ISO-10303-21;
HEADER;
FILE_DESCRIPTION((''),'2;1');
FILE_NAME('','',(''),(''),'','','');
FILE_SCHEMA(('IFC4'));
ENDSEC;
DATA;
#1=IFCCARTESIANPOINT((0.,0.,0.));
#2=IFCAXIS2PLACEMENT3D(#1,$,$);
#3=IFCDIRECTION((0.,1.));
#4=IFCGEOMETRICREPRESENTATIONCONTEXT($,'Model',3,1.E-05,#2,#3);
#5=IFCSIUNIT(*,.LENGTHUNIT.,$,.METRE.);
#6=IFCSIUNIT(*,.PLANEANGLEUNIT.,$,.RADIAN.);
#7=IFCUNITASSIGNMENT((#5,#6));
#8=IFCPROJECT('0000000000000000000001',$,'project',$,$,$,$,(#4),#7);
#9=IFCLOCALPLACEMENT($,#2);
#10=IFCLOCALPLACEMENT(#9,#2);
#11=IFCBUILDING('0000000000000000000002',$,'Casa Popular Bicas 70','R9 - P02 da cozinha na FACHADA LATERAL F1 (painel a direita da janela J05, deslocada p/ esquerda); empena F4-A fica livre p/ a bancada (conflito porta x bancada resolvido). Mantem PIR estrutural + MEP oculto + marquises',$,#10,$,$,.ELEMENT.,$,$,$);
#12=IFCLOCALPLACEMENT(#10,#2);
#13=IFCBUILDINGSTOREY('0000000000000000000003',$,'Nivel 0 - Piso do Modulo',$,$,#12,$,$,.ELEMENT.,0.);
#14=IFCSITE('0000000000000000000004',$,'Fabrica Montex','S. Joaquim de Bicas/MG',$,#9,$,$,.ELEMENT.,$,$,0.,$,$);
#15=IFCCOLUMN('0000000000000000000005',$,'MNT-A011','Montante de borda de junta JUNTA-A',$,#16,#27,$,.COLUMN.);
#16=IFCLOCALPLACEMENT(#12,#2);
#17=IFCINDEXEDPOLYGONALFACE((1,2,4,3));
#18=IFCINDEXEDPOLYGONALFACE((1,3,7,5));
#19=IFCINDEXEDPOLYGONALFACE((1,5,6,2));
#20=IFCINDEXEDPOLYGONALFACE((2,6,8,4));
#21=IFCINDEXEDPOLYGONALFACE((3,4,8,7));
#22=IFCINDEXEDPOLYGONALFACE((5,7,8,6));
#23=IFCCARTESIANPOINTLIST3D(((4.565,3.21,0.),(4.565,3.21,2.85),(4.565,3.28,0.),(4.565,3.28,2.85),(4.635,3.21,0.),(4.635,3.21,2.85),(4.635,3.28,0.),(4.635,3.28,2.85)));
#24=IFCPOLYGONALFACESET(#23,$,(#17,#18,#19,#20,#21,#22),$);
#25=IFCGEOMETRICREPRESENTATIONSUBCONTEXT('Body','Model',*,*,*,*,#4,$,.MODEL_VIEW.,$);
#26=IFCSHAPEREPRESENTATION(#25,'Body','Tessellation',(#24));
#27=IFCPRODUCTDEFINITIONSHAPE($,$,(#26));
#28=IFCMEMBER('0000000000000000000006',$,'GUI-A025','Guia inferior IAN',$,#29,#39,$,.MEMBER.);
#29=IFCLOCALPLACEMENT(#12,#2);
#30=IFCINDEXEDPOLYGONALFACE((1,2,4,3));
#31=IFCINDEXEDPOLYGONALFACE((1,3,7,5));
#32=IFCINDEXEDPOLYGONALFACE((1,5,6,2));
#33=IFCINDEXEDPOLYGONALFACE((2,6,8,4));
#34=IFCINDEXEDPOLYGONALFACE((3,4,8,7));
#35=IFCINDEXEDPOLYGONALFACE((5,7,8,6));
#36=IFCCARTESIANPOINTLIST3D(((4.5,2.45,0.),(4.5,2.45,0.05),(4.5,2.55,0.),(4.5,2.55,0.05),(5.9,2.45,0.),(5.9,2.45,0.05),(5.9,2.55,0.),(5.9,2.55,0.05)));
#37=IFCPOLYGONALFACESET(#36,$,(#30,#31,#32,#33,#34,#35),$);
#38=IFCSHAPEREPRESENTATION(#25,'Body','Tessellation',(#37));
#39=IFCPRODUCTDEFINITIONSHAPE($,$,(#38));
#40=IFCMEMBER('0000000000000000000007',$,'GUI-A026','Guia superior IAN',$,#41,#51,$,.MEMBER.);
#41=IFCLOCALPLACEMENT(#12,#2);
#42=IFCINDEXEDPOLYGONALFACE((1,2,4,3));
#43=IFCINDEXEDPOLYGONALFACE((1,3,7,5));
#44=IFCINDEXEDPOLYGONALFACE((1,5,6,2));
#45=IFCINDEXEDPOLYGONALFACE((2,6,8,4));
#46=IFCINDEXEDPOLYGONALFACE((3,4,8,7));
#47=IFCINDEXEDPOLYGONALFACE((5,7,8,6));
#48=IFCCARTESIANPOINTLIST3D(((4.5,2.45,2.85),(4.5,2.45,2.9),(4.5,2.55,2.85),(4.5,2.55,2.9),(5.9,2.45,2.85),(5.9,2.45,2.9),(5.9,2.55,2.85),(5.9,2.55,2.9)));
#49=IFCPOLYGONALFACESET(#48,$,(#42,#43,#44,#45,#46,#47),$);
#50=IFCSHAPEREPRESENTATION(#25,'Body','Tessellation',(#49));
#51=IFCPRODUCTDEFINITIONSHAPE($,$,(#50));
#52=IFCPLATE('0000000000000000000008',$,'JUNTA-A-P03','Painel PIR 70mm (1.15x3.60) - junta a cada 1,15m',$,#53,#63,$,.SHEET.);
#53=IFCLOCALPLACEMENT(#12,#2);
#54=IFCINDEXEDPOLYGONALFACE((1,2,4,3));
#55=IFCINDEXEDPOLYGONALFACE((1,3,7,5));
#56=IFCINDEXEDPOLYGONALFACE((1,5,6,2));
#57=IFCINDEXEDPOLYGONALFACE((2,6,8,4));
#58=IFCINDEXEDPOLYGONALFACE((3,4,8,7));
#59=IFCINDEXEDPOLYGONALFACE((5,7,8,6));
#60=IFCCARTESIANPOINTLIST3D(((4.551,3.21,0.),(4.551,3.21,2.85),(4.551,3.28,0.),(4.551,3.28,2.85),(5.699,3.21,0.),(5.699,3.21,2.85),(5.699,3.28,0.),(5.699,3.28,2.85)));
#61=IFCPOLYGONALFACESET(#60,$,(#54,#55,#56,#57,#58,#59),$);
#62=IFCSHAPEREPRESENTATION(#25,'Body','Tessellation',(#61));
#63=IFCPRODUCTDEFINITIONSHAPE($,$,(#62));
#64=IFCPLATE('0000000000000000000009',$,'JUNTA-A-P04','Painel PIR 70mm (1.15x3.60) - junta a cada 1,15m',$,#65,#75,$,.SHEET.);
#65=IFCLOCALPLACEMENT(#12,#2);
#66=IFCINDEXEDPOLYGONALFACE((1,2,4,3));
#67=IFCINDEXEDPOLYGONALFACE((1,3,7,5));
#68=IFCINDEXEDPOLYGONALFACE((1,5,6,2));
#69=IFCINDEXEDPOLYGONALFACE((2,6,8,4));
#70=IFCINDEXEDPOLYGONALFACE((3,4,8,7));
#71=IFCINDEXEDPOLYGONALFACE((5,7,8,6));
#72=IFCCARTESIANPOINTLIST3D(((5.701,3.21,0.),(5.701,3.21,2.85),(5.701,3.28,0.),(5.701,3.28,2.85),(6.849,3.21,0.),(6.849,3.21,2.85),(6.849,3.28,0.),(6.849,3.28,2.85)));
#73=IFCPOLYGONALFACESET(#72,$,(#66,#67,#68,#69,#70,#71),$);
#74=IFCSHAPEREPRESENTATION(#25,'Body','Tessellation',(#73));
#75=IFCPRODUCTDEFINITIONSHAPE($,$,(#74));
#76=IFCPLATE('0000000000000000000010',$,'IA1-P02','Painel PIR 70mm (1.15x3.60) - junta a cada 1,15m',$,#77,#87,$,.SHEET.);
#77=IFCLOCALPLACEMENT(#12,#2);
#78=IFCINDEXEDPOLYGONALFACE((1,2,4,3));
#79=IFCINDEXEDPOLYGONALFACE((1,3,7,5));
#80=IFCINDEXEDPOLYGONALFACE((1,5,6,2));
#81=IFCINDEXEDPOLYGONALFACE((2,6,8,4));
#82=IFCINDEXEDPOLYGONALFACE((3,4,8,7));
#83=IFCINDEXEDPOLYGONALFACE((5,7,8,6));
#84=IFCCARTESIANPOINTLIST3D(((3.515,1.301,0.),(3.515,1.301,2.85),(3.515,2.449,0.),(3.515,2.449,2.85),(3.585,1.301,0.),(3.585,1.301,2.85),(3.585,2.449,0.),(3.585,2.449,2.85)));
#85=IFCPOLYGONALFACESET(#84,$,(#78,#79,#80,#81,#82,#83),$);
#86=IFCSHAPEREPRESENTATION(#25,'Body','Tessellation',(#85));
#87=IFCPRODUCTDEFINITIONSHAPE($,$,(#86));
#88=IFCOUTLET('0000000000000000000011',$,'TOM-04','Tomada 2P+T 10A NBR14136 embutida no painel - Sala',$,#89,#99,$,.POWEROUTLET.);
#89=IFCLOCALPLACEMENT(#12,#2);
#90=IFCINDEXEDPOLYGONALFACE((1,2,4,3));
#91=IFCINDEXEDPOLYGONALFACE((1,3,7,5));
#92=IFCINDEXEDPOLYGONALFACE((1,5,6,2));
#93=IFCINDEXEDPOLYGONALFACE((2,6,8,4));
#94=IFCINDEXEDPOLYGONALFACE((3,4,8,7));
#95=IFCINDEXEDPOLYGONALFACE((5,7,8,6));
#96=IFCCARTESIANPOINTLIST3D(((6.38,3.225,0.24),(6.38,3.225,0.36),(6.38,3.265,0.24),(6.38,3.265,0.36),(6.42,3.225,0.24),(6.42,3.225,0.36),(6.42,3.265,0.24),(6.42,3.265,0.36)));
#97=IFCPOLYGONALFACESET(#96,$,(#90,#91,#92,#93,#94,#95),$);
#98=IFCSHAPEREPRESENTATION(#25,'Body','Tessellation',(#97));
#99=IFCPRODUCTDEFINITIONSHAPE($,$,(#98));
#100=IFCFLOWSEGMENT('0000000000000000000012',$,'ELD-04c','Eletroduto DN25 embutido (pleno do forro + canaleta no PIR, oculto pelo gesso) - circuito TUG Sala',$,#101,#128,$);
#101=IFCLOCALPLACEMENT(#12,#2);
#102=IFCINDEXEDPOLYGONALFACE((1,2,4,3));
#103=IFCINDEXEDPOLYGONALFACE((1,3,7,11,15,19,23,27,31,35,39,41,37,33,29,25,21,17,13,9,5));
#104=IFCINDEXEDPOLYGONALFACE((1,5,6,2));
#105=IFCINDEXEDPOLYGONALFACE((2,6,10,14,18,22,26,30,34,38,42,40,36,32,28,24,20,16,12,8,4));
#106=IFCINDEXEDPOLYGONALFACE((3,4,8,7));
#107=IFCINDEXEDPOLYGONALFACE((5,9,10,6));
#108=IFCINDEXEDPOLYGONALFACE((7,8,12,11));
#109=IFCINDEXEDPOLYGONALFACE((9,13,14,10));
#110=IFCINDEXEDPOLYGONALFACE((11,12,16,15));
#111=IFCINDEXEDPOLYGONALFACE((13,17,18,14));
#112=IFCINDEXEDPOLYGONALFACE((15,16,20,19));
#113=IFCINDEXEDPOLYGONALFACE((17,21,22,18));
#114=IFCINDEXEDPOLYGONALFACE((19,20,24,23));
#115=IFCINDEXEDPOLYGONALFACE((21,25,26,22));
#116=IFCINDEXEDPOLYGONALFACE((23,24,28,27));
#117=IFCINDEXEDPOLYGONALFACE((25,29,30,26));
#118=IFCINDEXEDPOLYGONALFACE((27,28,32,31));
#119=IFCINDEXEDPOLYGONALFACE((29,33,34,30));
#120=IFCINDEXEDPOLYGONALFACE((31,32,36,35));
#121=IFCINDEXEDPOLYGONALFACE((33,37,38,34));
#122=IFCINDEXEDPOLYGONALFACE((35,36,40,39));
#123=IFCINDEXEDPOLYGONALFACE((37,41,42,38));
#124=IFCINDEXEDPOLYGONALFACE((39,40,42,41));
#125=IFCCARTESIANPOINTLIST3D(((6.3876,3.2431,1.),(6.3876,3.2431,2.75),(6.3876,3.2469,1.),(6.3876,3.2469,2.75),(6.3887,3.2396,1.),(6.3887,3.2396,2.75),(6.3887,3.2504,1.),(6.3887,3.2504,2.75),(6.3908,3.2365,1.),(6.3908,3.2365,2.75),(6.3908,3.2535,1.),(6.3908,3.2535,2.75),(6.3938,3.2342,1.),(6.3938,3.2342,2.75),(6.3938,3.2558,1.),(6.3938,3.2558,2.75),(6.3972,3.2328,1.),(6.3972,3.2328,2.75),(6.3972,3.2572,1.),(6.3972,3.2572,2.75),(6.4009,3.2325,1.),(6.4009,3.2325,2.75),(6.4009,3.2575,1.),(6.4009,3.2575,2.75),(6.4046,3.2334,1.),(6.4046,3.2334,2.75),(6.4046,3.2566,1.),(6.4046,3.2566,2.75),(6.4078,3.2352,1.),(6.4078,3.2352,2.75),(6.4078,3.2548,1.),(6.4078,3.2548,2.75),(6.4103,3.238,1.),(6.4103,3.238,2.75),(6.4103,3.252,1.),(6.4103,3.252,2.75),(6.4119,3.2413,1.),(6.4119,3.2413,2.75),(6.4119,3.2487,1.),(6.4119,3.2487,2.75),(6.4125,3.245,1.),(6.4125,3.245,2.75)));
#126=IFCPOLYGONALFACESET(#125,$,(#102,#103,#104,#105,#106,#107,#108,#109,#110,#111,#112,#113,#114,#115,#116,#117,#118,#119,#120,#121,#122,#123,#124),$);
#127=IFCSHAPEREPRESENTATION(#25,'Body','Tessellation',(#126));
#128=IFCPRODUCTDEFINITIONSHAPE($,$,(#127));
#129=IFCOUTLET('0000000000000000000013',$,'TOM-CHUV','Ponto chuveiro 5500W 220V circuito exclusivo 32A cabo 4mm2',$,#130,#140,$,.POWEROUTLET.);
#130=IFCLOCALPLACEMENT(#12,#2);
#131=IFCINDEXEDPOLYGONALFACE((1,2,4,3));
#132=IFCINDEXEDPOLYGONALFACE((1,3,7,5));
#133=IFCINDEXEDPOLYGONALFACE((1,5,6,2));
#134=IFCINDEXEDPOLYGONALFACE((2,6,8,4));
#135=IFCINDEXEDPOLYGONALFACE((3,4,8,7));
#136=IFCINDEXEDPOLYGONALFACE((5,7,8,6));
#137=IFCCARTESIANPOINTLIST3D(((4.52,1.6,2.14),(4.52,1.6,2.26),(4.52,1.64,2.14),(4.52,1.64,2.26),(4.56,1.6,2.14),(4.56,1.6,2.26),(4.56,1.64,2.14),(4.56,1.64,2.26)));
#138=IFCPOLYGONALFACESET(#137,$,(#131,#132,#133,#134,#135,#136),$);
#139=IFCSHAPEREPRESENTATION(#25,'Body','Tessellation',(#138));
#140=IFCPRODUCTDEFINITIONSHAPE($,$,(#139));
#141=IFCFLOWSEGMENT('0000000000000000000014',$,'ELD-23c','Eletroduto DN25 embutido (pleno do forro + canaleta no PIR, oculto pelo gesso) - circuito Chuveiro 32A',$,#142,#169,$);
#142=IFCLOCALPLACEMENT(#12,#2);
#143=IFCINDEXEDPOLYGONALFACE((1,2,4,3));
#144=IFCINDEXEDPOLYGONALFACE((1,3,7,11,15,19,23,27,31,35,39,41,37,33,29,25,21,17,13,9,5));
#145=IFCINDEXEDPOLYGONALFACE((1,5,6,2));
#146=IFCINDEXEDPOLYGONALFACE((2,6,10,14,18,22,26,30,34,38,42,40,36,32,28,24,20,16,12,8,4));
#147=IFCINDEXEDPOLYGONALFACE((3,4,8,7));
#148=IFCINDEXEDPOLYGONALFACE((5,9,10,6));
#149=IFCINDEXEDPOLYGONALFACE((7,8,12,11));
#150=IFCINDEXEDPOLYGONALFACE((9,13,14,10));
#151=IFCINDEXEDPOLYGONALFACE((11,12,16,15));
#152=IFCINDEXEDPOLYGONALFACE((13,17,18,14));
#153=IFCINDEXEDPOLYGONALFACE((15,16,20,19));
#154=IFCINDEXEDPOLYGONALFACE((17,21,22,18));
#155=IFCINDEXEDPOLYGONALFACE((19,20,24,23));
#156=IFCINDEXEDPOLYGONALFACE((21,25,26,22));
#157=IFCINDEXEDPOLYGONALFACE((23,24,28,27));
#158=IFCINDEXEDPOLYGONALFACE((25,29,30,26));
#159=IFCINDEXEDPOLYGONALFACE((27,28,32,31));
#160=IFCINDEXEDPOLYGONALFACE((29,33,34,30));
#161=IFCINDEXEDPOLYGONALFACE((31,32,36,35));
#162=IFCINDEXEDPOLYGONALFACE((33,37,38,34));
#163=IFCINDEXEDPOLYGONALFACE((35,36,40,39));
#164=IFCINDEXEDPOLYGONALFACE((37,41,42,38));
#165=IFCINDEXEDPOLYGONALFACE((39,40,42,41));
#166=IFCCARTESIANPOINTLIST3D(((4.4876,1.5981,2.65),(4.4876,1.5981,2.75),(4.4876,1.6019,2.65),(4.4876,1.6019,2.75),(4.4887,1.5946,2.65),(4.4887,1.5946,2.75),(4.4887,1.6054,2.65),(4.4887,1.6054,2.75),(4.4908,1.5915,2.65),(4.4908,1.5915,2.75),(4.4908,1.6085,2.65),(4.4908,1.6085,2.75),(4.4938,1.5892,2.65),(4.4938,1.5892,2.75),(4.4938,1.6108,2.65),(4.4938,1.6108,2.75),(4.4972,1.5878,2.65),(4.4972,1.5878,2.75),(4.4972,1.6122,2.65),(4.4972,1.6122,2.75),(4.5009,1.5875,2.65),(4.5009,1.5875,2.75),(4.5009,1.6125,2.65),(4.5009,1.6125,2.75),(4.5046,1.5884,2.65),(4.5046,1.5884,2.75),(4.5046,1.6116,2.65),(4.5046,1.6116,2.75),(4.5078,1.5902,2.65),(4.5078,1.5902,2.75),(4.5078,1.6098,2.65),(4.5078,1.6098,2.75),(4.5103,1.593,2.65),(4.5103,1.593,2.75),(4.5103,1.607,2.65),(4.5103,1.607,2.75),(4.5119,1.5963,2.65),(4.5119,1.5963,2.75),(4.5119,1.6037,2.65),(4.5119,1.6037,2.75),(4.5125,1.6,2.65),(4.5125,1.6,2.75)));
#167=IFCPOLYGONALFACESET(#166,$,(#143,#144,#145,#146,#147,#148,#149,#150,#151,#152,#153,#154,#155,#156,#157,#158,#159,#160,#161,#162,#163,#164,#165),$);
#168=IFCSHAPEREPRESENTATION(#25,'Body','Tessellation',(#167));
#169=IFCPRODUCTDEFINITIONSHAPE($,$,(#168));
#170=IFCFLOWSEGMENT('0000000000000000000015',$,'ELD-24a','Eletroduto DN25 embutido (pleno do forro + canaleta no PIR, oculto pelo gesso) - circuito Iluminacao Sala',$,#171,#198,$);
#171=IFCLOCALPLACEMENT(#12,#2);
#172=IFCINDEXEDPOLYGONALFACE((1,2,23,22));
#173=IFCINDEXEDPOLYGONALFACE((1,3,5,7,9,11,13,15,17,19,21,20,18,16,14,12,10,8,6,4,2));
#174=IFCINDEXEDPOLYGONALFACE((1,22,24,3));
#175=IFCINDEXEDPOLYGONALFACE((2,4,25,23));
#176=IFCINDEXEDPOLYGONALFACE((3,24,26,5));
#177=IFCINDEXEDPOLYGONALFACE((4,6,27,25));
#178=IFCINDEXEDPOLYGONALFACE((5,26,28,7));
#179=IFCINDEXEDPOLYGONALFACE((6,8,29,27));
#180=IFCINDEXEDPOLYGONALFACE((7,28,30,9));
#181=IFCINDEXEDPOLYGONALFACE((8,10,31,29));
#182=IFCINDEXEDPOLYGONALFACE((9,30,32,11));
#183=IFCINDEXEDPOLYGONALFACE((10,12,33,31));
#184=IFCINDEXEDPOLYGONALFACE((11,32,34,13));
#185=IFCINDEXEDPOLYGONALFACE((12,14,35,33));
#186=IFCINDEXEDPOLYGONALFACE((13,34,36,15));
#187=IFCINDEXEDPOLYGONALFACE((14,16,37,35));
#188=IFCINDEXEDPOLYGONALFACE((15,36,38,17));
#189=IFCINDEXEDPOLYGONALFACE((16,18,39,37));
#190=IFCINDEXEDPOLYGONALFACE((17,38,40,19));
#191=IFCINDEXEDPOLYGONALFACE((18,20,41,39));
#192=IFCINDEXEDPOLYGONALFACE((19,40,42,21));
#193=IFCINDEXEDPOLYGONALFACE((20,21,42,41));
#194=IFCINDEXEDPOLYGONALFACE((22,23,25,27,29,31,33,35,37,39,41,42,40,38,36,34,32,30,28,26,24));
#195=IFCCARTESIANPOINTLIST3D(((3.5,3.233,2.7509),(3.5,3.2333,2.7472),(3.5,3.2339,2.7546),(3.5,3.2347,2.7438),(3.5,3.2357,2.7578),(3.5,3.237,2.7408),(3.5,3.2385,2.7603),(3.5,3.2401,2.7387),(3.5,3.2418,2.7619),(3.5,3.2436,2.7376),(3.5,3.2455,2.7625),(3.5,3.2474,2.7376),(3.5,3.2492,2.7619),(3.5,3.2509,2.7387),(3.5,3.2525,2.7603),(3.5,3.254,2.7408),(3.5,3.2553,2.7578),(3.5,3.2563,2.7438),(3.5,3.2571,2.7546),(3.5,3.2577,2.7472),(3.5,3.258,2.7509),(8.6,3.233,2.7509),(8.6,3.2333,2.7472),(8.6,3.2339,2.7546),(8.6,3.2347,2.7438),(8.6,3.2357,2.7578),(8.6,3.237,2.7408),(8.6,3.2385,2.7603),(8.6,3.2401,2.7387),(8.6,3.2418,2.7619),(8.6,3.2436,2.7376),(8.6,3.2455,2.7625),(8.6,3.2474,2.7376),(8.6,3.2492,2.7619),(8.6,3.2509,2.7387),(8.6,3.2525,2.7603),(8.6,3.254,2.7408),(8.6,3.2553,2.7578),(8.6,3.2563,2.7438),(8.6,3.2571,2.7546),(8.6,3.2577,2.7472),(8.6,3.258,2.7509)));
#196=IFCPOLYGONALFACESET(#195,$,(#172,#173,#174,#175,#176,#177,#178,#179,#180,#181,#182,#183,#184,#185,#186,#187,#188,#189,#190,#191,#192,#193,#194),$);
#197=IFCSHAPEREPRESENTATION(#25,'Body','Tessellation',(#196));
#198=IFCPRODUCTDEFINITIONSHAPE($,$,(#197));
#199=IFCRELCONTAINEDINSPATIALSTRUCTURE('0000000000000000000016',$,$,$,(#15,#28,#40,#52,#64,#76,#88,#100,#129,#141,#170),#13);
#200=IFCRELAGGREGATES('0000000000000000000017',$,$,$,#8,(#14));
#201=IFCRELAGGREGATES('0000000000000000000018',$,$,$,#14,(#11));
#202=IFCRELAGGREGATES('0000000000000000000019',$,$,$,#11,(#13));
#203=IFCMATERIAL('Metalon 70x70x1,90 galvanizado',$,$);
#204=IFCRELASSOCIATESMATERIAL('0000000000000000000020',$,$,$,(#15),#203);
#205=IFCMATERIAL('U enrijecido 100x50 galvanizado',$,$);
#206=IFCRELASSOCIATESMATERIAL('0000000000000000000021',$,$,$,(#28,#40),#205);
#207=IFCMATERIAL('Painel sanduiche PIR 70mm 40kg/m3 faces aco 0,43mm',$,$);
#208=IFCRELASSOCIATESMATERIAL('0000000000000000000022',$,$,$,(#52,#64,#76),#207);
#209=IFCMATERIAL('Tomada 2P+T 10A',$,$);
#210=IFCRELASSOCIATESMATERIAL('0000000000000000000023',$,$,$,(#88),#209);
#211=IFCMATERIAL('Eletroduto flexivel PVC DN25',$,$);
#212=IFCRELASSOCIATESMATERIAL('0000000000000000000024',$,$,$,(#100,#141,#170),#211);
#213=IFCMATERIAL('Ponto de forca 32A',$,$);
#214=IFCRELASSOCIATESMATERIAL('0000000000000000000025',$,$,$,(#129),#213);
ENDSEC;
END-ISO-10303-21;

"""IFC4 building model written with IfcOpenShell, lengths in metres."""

from ifc_helpers import new_model, si_unit, direction, frame, frame_2d, origin, origin_2d, place, context, subcontext, project, spatial, rectangle, circle, extrude, material, element, save


model = new_model("IFC4")

# Units and contexts
model_context = context("Model", 3, precision=1e-05, world=origin(), true_north=direction((0.0, 1.0)))
body_context = subcontext(model_context, "Body", "Model", "MODEL_VIEW")
ifc_project = project(units=[si_unit("LENGTHUNIT", "METRE"), si_unit("PLANEANGLEUNIT", "RADIAN")], contexts=[model_context])

# Site, building, storey
site_placement = place(None, origin())
site = spatial("IfcSite", under=ifc_project, at=site_placement, Name="Fabrica Montex", Description="S. Joaquim de Bicas/MG", CompositionType="ELEMENT", RefElevation=0.0)
building_placement = place(site_placement, origin())
building = spatial("IfcBuilding", under=site, at=building_placement, Name="Casa Popular Bicas 70", Description="R9 - P02 da cozinha na FACHADA LATERAL F1 (painel a direita da janela J05, deslocada p/ esquerda); empena F4-A fica livre p/ a bancada (conflito porta x bancada resolvido). Mantem PIR estrutural + MEP oculto + marquises", CompositionType="ELEMENT")
storey_placement = place(building_placement, origin())
storey = spatial("IfcBuildingStorey", under=building, at=storey_placement, Name="Nivel 0 - Piso do Modulo", CompositionType="ELEMENT", Elevation=0.0)

# Column
ifc_material_1 = material(Name="Metalon 70x70x1,90 galvanizado")
column_placement = place(storey_placement, frame((4.6, 3.245, 0.0)))
element("IfcColumn", 1, at=column_placement, inside=storey, material=ifc_material_1, Name="MNT-A011", Description="Montante de borda de junta JUNTA-A", PredefinedType="COLUMN", context=body_context, shape_type="SweptSolid", body=[
    extrude(rectangle(XDim=0.07, YDim=0.07, at=origin_2d()), origin(), (0.0, 0.0, 1.0), 2.85),
])

# Members
ifc_material_2 = material(Name="U enrijecido 100x50 galvanizado")
for number, where, z_axis, x_axis, name, description in (
    (2, (4.5, 2.5, 0.025), (1.0, 0.0, 0.0), (0.0, 0.0, 1.0), "GUI-A025", "Guia inferior IAN"),
    (3, (4.5, 2.5, 2.875), (1.0, 0.0, 0.0), (0.0, 0.0, 1.0), "GUI-A026", "Guia superior IAN"),
):
    element("IfcMember", number, at=place(storey_placement, frame(where, z_axis=z_axis, x_axis=x_axis)), inside=storey, material=ifc_material_2, Name=name, Description=description, PredefinedType="MEMBER", context=body_context, shape_type="SweptSolid", body=[
        extrude(rectangle(XDim=0.05, YDim=0.1, at=origin_2d()), origin(), (0.0, 0.0, 1.0), 1.4),
    ])

# Plates
ifc_material_3 = material(Name="Painel sanduiche PIR 70mm 40kg/m3 faces aco 0,43mm")
for number, where, x_axis, name in (
    (4, (4.551, 3.245, 0.0), (1.0, 0.0, 0.0), "JUNTA-A-P03"),
    (5, (5.701, 3.245, 0.0), (1.0, 0.0, 0.0), "JUNTA-A-P04"),
    (6, (3.55, 1.301, 0.0), (0.0, 1.0, 0.0), "IA1-P02"),
):
    element("IfcPlate", number, at=place(storey_placement, frame(where, x_axis=x_axis)), inside=storey, material=ifc_material_3, Name=name, Description="Painel PIR 70mm (1.15x3.60) - junta a cada 1,15m", PredefinedType="SHEET", context=body_context, shape_type="SweptSolid", body=[
        extrude(rectangle(XDim=1.148, YDim=0.07, at=frame_2d((0.574, 0.0))), origin(), (0.0, 0.0, 1.0), 2.85),
    ])

# Outlet
ifc_material_4 = material(Name="Tomada 2P+T 10A")
outlet_1_placement = place(storey_placement, frame((6.38, 3.225, 0.24)))
element("IfcOutlet", 7, at=outlet_1_placement, inside=storey, material=ifc_material_4, Name="TOM-04", Description="Tomada 2P+T 10A NBR14136 embutida no painel - Sala", PredefinedType="POWEROUTLET", context=body_context, shape_type="SweptSolid", body=[
    extrude(rectangle(XDim=0.04, YDim=0.04, at=frame_2d((0.02, 0.02))), origin(), (0.0, 0.0, 1.0), 0.12),
])

# Flow segment
ifc_material_5 = material(Name="Eletroduto flexivel PVC DN25")
flow_segment_1_placement = place(storey_placement, frame((6.4, 3.245, 2.75), z_axis=(0.0, 0.0, -1.0), x_axis=(1.0, 0.0, 0.0)))
element("IfcFlowSegment", 8, at=flow_segment_1_placement, inside=storey, material=ifc_material_5, Name="ELD-04c", Description="Eletroduto DN25 embutido (pleno do forro + canaleta no PIR, oculto pelo gesso) - circuito TUG Sala", context=body_context, shape_type="SweptSolid", body=[
    extrude(circle(Radius=0.0125, at=origin_2d()), origin(), (0.0, 0.0, 1.0), 1.75),
])

# Outlet
ifc_material_6 = material(Name="Ponto de forca 32A")
outlet_2_placement = place(storey_placement, frame((4.52, 1.6, 2.14)))
element("IfcOutlet", 9, at=outlet_2_placement, inside=storey, material=ifc_material_6, Name="TOM-CHUV", Description="Ponto chuveiro 5500W 220V circuito exclusivo 32A cabo 4mm2", PredefinedType="POWEROUTLET", context=body_context, shape_type="SweptSolid", body=[
    extrude(rectangle(XDim=0.04, YDim=0.04, at=frame_2d((0.02, 0.02))), origin(), (0.0, 0.0, 1.0), 0.12),
])

# Flow segments
flow_segment_2_placement = place(storey_placement, frame((4.5, 1.6, 2.75), z_axis=(0.0, 0.0, -1.0), x_axis=(1.0, 0.0, 0.0)))
element("IfcFlowSegment", 10, at=flow_segment_2_placement, inside=storey, material=ifc_material_5, Name="ELD-23c", Description="Eletroduto DN25 embutido (pleno do forro + canaleta no PIR, oculto pelo gesso) - circuito Chuveiro 32A", context=body_context, shape_type="SweptSolid", body=[
    extrude(circle(Radius=0.0125, at=origin_2d()), origin(), (0.0, 0.0, 1.0), 0.1),
])
flow_segment_3_placement = place(storey_placement, frame((3.5, 3.2455, 2.75), z_axis=(1.0, 0.0, 0.0), x_axis=(0.0, 0.0, 1.0)))
element("IfcFlowSegment", 11, at=flow_segment_3_placement, inside=storey, material=ifc_material_5, Name="ELD-24a", Description="Eletroduto DN25 embutido (pleno do forro + canaleta no PIR, oculto pelo gesso) - circuito Iluminacao Sala", context=body_context, shape_type="SweptSolid", body=[
    extrude(circle(Radius=0.0125, at=origin_2d()), origin(), (0.0, 0.0, 1.0), 5.1),
])

save(model, "model.ifc")
